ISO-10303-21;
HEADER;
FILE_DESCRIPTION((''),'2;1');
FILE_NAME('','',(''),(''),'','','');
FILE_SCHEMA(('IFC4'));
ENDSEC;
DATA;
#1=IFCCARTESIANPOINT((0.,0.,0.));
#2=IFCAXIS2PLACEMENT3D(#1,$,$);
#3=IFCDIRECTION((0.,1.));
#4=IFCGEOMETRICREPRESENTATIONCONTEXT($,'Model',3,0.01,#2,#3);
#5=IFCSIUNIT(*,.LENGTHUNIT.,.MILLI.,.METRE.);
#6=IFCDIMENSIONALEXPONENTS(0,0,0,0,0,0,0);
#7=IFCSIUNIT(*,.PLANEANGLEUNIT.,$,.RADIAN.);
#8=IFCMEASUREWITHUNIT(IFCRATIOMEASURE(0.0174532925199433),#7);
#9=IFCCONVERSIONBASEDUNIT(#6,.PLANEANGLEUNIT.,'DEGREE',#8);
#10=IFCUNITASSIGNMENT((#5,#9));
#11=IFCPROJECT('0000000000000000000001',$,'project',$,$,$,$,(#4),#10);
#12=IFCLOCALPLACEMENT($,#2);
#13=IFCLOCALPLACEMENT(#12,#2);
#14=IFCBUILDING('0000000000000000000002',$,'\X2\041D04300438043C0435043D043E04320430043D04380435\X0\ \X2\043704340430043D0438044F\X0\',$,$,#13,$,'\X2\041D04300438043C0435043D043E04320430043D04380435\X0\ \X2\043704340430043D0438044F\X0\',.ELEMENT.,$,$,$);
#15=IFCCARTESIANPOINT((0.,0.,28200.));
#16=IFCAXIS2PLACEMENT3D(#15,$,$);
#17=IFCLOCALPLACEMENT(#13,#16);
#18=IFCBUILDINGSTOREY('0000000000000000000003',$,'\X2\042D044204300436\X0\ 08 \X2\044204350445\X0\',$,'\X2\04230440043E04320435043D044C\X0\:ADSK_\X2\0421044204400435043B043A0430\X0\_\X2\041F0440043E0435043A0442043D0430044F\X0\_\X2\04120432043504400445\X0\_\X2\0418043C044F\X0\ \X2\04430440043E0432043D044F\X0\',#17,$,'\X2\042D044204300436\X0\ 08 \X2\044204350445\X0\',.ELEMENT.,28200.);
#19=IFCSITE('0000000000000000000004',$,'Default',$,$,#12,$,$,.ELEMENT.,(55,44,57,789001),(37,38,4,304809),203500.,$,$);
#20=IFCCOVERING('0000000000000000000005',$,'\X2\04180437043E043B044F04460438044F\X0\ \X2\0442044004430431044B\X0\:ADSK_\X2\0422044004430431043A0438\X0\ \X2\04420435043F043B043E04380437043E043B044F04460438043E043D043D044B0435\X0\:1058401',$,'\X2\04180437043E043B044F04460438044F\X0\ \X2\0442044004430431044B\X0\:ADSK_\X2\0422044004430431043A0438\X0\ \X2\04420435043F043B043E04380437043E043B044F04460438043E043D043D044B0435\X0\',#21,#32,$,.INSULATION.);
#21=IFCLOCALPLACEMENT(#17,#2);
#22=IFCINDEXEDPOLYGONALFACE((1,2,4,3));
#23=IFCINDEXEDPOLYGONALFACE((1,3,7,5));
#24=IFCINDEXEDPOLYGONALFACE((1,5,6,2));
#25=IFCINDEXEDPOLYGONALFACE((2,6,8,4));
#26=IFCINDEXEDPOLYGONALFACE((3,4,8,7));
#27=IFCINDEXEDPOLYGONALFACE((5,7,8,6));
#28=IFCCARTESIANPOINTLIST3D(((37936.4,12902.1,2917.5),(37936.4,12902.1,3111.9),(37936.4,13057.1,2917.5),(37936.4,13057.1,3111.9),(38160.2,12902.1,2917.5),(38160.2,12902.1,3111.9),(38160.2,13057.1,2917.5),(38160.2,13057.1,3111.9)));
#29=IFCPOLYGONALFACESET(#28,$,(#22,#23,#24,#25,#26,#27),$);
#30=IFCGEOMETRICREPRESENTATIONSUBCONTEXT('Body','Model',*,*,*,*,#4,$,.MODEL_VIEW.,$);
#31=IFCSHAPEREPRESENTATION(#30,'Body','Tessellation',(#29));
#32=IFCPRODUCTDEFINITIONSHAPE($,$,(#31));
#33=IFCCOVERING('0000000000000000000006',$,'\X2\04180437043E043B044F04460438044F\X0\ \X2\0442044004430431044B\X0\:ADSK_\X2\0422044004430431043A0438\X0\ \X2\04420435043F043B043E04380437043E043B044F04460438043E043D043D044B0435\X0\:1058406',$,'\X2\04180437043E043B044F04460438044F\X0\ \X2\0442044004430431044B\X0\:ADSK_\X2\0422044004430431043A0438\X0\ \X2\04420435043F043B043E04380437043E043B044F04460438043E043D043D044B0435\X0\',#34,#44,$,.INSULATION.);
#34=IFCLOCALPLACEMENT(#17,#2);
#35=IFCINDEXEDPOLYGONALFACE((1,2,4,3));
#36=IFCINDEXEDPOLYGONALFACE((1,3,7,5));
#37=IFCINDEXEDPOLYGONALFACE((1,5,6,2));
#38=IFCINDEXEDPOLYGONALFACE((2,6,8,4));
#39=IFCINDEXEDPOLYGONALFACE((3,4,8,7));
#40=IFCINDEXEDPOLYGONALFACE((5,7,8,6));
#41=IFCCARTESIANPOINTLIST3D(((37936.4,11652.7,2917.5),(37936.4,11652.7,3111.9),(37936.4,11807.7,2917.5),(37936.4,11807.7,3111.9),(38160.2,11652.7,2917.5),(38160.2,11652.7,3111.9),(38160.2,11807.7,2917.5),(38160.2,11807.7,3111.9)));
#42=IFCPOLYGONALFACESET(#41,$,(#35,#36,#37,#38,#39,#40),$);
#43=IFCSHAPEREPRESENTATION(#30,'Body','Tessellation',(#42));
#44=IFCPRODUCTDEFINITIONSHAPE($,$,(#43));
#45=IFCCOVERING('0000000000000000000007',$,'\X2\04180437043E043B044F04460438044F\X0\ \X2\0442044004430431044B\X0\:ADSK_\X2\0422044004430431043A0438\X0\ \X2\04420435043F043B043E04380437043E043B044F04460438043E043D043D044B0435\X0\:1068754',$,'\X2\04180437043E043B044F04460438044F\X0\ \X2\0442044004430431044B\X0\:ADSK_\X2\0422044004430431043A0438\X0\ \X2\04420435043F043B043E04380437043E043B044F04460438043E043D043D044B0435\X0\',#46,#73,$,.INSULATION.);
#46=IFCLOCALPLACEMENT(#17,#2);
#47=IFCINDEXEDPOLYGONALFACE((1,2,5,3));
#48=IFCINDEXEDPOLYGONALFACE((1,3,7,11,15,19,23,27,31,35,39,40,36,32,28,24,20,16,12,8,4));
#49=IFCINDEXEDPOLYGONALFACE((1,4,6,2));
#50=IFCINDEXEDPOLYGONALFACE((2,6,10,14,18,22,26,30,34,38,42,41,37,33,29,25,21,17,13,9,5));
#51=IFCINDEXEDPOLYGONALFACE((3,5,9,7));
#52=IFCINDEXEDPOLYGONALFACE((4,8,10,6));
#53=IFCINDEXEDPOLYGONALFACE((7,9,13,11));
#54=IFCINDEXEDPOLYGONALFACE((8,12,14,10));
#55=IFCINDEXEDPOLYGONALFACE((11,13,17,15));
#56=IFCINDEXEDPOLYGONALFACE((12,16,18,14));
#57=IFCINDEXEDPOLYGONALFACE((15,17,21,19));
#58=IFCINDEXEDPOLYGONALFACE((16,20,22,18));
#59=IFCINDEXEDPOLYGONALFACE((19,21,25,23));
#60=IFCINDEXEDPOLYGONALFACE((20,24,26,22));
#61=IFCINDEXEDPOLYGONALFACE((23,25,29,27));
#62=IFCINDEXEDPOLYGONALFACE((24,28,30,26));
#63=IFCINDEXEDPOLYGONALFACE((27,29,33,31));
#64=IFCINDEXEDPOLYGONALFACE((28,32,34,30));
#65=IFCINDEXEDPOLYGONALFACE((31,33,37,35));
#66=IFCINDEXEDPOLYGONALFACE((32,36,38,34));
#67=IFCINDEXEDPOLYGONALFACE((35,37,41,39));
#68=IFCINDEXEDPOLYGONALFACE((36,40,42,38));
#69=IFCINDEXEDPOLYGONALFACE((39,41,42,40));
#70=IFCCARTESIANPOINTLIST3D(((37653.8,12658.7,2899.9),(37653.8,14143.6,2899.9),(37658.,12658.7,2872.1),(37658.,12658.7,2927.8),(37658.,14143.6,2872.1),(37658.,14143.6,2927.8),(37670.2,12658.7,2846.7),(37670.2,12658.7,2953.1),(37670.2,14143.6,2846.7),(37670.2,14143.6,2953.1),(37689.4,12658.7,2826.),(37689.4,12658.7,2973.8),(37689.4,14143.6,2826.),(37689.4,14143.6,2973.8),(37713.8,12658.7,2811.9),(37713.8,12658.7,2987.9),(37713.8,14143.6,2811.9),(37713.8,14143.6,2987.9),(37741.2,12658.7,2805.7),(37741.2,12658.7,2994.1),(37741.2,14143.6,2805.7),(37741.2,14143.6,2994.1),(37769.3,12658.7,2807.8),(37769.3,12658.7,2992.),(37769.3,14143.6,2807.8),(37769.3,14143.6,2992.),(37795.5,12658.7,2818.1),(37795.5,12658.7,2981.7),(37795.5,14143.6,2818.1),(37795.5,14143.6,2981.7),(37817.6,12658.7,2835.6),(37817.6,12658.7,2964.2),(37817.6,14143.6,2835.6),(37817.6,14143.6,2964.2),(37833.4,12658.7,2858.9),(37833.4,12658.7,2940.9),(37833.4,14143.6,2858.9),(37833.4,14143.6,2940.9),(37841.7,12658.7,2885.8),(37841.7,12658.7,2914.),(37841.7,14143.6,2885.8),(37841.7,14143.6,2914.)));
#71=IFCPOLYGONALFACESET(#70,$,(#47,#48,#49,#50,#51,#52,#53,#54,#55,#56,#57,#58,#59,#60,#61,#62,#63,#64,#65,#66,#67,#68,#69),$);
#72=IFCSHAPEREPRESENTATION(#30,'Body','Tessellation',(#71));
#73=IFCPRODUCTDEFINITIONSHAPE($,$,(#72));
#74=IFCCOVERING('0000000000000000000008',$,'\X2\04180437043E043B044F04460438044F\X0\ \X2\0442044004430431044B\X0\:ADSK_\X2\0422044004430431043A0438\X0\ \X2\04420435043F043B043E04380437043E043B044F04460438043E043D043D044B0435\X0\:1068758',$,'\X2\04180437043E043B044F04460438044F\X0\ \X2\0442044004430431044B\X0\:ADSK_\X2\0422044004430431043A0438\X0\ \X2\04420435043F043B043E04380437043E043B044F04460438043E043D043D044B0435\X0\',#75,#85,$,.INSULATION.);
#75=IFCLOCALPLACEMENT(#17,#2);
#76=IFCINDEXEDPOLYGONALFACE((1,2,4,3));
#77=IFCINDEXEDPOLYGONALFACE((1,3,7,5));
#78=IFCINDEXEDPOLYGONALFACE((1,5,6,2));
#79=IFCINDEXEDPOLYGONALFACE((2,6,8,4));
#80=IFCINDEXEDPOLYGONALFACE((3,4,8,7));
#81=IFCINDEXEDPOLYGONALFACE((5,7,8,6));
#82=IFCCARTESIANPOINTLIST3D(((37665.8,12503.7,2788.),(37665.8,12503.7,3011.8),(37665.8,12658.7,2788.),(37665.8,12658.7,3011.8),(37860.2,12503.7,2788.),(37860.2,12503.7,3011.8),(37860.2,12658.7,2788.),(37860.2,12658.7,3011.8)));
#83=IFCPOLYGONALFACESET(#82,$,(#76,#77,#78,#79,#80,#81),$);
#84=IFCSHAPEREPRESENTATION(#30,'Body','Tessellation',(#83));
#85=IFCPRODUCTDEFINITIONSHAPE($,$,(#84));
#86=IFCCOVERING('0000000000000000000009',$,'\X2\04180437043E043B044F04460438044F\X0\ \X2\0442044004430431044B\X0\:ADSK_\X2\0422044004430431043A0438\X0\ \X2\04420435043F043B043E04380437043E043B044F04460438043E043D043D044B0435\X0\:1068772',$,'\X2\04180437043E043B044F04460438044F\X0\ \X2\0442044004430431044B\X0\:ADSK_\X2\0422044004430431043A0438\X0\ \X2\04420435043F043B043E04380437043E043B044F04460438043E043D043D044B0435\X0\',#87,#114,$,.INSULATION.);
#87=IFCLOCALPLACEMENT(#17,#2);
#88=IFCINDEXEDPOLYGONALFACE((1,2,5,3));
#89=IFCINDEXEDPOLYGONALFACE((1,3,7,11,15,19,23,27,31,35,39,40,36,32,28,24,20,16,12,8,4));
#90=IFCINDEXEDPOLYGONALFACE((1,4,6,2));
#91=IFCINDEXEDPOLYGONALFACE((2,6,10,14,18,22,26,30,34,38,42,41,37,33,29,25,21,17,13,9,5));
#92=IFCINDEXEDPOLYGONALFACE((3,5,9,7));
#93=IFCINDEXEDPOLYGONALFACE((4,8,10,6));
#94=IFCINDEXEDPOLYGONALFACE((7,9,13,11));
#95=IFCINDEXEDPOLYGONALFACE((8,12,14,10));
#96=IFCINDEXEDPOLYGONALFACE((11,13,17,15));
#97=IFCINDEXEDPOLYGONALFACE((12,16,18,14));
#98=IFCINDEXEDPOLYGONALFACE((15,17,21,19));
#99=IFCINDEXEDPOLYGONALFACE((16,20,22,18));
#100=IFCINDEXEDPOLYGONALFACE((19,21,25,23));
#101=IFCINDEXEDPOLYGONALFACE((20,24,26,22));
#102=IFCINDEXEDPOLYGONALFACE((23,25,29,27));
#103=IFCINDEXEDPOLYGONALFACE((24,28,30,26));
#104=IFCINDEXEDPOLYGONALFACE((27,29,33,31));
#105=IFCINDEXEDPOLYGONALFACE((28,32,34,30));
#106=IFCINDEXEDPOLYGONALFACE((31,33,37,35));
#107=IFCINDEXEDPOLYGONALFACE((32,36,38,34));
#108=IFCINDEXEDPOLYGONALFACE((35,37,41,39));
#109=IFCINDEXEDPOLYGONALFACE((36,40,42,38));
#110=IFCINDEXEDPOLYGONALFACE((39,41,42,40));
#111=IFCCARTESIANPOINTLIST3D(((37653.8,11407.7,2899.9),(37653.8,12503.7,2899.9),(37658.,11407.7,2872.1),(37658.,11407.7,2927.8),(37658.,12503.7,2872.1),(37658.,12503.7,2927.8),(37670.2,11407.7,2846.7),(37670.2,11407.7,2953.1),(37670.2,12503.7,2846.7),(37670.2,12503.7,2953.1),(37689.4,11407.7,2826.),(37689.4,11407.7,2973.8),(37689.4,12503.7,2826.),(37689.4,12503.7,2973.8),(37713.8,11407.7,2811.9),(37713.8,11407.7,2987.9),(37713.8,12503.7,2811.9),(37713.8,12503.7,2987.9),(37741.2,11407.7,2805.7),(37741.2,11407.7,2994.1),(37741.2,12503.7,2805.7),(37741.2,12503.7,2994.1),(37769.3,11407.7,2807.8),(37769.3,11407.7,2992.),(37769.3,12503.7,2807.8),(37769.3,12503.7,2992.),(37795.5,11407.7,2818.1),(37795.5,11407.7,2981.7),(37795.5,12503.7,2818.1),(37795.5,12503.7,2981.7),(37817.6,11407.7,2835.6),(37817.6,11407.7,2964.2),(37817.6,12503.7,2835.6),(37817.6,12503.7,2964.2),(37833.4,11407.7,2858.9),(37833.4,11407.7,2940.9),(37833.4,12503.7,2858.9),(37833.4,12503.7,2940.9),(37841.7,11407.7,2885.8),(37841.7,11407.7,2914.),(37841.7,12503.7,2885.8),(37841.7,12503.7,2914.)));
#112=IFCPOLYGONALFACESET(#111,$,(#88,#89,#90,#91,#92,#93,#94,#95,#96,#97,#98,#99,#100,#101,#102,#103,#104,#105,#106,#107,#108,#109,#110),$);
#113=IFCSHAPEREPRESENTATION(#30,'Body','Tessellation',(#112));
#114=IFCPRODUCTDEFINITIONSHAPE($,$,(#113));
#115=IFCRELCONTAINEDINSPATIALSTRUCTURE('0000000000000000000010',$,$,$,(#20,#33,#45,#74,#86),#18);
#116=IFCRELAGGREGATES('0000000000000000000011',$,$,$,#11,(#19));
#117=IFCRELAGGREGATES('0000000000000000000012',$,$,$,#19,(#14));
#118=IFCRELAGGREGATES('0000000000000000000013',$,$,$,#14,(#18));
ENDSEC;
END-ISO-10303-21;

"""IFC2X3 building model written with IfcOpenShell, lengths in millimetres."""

from ifc_helpers import new_model, entity, si_unit, converted_unit, direction, frame, origin, origin_2d_with_axis, place, context, subcontext, project, spatial, rectangle, circle, extrude, element, save


model = new_model("IFC2X3")

# Units and contexts
model_context = context("Model", 3, precision=0.01, world=origin(), true_north=direction((0.0, 1.0)))
body_context = subcontext(model_context, "Body", "Model", "MODEL_VIEW")
ifc_project = project(units=[si_unit("LENGTHUNIT", "METRE", prefix="MILLI"), converted_unit("PLANEANGLEUNIT", "DEGREE", entity("IfcRatioMeasure", 0.0174532925199433), si_unit("PLANEANGLEUNIT", "RADIAN"), dimensions=[0, 0, 0, 0, 0, 0, 0])], contexts=[model_context])

# Site, building, storey
site_placement = place(None, origin())
site = spatial("IfcSite", under=ifc_project, at=site_placement, Name="Default", CompositionType="ELEMENT", RefLatitude=(55, 44, 57, 789001), RefLongitude=(37, 38, 4, 304809), RefElevation=203500.0)
building_placement = place(site_placement, origin())
building = spatial("IfcBuilding", under=site, at=building_placement, Name="Наименование здания", LongName="Наименование здания", CompositionType="ELEMENT")
storey_placement = place(building_placement, frame((0.0, 0.0, 28200.0)))
storey = spatial("IfcBuildingStorey", under=building, at=storey_placement, Name="Этаж 08 тех", ObjectType="Уровень:ADSK_Стрелка_Проектная_Вверх_Имя уровня", LongName="Этаж 08 тех", CompositionType="ELEMENT", Elevation=28200.0)

# Coverings
covering_1_placement = place(storey_placement, frame((37936.4, 12902.1, 2917.5)))
element("IfcCovering", 1, at=covering_1_placement, inside=storey, Name="Изоляция трубы:ADSK_Трубки теплоизоляционные:1058401", ObjectType="Изоляция трубы:ADSK_Трубки теплоизоляционные", PredefinedType="INSULATION", context=body_context, shape_type="SweptSolid", body=[
    extrude(rectangle(XDim=155.0, YDim=223.8, at=origin_2d_with_axis()), frame((111.9, 77.5, 0.0), z_axis=(0.0, 0.0, 1.0), x_axis=(0.0, -1.0, 0.0)), (0.0, 0.0, 1.0), 194.4),
])
covering_2_placement = place(storey_placement, frame((37936.4, 11652.7, 2917.5)))
element("IfcCovering", 2, at=covering_2_placement, inside=storey, Name="Изоляция трубы:ADSK_Трубки теплоизоляционные:1058406", ObjectType="Изоляция трубы:ADSK_Трубки теплоизоляционные", PredefinedType="INSULATION", context=body_context, shape_type="SweptSolid", body=[
    extrude(rectangle(XDim=155.0, YDim=223.8, at=origin_2d_with_axis()), frame((111.9, 77.5, 0.0), z_axis=(0.0, 0.0, 1.0), x_axis=(0.0, -1.0, 0.0)), (0.0, 0.0, 1.0), 194.4),
])
covering_3_placement = place(storey_placement, frame((37652.2, 12658.7, 2803.8)))
element("IfcCovering", 3, at=covering_3_placement, inside=storey, Name="Изоляция трубы:ADSK_Трубки теплоизоляционные:1068754", ObjectType="Изоляция трубы:ADSK_Трубки теплоизоляционные", PredefinedType="INSULATION", context=body_context, shape_type="SweptSolid", body=[
    extrude(circle(Radius=94.5, at=origin_2d_with_axis()), frame((96.1, 0.0, 96.1), z_axis=(0.0, 1.0, -0.000001), x_axis=(-1.0, 0.0, 0.0)), (0.0, 0.0, 1.0), 1484.9),
])
covering_4_placement = place(storey_placement, frame((37665.8, 12503.7, 2788.0)))
element("IfcCovering", 4, at=covering_4_placement, inside=storey, Name="Изоляция трубы:ADSK_Трубки теплоизоляционные:1068758", ObjectType="Изоляция трубы:ADSK_Трубки теплоизоляционные", PredefinedType="INSULATION", context=body_context, shape_type="SweptSolid", body=[
    extrude(rectangle(XDim=155.0, YDim=194.4, at=origin_2d_with_axis()), frame((97.2, 77.5, 0.0), z_axis=(0.0, 0.0, 1.0), x_axis=(0.0, -1.0, 0.0)), (0.0, 0.0, 1.0), 223.8),
])
covering_5_placement = place(storey_placement, frame((37652.2, 11407.7, 2803.8)))
element("IfcCovering", 5, at=covering_5_placement, inside=storey, Name="Изоляция трубы:ADSK_Трубки теплоизоляционные:1068772", ObjectType="Изоляция трубы:ADSK_Трубки теплоизоляционные", PredefinedType="INSULATION", context=body_context, shape_type="SweptSolid", body=[
    extrude(circle(Radius=94.5, at=origin_2d_with_axis()), frame((96.1, 0.0, 96.1), z_axis=(0.0, 1.0, -0.000001), x_axis=(-1.0, 0.0, 0.0)), (0.0, 0.0, 1.0), 1096.0),
])

save(model, "model.ifc")
